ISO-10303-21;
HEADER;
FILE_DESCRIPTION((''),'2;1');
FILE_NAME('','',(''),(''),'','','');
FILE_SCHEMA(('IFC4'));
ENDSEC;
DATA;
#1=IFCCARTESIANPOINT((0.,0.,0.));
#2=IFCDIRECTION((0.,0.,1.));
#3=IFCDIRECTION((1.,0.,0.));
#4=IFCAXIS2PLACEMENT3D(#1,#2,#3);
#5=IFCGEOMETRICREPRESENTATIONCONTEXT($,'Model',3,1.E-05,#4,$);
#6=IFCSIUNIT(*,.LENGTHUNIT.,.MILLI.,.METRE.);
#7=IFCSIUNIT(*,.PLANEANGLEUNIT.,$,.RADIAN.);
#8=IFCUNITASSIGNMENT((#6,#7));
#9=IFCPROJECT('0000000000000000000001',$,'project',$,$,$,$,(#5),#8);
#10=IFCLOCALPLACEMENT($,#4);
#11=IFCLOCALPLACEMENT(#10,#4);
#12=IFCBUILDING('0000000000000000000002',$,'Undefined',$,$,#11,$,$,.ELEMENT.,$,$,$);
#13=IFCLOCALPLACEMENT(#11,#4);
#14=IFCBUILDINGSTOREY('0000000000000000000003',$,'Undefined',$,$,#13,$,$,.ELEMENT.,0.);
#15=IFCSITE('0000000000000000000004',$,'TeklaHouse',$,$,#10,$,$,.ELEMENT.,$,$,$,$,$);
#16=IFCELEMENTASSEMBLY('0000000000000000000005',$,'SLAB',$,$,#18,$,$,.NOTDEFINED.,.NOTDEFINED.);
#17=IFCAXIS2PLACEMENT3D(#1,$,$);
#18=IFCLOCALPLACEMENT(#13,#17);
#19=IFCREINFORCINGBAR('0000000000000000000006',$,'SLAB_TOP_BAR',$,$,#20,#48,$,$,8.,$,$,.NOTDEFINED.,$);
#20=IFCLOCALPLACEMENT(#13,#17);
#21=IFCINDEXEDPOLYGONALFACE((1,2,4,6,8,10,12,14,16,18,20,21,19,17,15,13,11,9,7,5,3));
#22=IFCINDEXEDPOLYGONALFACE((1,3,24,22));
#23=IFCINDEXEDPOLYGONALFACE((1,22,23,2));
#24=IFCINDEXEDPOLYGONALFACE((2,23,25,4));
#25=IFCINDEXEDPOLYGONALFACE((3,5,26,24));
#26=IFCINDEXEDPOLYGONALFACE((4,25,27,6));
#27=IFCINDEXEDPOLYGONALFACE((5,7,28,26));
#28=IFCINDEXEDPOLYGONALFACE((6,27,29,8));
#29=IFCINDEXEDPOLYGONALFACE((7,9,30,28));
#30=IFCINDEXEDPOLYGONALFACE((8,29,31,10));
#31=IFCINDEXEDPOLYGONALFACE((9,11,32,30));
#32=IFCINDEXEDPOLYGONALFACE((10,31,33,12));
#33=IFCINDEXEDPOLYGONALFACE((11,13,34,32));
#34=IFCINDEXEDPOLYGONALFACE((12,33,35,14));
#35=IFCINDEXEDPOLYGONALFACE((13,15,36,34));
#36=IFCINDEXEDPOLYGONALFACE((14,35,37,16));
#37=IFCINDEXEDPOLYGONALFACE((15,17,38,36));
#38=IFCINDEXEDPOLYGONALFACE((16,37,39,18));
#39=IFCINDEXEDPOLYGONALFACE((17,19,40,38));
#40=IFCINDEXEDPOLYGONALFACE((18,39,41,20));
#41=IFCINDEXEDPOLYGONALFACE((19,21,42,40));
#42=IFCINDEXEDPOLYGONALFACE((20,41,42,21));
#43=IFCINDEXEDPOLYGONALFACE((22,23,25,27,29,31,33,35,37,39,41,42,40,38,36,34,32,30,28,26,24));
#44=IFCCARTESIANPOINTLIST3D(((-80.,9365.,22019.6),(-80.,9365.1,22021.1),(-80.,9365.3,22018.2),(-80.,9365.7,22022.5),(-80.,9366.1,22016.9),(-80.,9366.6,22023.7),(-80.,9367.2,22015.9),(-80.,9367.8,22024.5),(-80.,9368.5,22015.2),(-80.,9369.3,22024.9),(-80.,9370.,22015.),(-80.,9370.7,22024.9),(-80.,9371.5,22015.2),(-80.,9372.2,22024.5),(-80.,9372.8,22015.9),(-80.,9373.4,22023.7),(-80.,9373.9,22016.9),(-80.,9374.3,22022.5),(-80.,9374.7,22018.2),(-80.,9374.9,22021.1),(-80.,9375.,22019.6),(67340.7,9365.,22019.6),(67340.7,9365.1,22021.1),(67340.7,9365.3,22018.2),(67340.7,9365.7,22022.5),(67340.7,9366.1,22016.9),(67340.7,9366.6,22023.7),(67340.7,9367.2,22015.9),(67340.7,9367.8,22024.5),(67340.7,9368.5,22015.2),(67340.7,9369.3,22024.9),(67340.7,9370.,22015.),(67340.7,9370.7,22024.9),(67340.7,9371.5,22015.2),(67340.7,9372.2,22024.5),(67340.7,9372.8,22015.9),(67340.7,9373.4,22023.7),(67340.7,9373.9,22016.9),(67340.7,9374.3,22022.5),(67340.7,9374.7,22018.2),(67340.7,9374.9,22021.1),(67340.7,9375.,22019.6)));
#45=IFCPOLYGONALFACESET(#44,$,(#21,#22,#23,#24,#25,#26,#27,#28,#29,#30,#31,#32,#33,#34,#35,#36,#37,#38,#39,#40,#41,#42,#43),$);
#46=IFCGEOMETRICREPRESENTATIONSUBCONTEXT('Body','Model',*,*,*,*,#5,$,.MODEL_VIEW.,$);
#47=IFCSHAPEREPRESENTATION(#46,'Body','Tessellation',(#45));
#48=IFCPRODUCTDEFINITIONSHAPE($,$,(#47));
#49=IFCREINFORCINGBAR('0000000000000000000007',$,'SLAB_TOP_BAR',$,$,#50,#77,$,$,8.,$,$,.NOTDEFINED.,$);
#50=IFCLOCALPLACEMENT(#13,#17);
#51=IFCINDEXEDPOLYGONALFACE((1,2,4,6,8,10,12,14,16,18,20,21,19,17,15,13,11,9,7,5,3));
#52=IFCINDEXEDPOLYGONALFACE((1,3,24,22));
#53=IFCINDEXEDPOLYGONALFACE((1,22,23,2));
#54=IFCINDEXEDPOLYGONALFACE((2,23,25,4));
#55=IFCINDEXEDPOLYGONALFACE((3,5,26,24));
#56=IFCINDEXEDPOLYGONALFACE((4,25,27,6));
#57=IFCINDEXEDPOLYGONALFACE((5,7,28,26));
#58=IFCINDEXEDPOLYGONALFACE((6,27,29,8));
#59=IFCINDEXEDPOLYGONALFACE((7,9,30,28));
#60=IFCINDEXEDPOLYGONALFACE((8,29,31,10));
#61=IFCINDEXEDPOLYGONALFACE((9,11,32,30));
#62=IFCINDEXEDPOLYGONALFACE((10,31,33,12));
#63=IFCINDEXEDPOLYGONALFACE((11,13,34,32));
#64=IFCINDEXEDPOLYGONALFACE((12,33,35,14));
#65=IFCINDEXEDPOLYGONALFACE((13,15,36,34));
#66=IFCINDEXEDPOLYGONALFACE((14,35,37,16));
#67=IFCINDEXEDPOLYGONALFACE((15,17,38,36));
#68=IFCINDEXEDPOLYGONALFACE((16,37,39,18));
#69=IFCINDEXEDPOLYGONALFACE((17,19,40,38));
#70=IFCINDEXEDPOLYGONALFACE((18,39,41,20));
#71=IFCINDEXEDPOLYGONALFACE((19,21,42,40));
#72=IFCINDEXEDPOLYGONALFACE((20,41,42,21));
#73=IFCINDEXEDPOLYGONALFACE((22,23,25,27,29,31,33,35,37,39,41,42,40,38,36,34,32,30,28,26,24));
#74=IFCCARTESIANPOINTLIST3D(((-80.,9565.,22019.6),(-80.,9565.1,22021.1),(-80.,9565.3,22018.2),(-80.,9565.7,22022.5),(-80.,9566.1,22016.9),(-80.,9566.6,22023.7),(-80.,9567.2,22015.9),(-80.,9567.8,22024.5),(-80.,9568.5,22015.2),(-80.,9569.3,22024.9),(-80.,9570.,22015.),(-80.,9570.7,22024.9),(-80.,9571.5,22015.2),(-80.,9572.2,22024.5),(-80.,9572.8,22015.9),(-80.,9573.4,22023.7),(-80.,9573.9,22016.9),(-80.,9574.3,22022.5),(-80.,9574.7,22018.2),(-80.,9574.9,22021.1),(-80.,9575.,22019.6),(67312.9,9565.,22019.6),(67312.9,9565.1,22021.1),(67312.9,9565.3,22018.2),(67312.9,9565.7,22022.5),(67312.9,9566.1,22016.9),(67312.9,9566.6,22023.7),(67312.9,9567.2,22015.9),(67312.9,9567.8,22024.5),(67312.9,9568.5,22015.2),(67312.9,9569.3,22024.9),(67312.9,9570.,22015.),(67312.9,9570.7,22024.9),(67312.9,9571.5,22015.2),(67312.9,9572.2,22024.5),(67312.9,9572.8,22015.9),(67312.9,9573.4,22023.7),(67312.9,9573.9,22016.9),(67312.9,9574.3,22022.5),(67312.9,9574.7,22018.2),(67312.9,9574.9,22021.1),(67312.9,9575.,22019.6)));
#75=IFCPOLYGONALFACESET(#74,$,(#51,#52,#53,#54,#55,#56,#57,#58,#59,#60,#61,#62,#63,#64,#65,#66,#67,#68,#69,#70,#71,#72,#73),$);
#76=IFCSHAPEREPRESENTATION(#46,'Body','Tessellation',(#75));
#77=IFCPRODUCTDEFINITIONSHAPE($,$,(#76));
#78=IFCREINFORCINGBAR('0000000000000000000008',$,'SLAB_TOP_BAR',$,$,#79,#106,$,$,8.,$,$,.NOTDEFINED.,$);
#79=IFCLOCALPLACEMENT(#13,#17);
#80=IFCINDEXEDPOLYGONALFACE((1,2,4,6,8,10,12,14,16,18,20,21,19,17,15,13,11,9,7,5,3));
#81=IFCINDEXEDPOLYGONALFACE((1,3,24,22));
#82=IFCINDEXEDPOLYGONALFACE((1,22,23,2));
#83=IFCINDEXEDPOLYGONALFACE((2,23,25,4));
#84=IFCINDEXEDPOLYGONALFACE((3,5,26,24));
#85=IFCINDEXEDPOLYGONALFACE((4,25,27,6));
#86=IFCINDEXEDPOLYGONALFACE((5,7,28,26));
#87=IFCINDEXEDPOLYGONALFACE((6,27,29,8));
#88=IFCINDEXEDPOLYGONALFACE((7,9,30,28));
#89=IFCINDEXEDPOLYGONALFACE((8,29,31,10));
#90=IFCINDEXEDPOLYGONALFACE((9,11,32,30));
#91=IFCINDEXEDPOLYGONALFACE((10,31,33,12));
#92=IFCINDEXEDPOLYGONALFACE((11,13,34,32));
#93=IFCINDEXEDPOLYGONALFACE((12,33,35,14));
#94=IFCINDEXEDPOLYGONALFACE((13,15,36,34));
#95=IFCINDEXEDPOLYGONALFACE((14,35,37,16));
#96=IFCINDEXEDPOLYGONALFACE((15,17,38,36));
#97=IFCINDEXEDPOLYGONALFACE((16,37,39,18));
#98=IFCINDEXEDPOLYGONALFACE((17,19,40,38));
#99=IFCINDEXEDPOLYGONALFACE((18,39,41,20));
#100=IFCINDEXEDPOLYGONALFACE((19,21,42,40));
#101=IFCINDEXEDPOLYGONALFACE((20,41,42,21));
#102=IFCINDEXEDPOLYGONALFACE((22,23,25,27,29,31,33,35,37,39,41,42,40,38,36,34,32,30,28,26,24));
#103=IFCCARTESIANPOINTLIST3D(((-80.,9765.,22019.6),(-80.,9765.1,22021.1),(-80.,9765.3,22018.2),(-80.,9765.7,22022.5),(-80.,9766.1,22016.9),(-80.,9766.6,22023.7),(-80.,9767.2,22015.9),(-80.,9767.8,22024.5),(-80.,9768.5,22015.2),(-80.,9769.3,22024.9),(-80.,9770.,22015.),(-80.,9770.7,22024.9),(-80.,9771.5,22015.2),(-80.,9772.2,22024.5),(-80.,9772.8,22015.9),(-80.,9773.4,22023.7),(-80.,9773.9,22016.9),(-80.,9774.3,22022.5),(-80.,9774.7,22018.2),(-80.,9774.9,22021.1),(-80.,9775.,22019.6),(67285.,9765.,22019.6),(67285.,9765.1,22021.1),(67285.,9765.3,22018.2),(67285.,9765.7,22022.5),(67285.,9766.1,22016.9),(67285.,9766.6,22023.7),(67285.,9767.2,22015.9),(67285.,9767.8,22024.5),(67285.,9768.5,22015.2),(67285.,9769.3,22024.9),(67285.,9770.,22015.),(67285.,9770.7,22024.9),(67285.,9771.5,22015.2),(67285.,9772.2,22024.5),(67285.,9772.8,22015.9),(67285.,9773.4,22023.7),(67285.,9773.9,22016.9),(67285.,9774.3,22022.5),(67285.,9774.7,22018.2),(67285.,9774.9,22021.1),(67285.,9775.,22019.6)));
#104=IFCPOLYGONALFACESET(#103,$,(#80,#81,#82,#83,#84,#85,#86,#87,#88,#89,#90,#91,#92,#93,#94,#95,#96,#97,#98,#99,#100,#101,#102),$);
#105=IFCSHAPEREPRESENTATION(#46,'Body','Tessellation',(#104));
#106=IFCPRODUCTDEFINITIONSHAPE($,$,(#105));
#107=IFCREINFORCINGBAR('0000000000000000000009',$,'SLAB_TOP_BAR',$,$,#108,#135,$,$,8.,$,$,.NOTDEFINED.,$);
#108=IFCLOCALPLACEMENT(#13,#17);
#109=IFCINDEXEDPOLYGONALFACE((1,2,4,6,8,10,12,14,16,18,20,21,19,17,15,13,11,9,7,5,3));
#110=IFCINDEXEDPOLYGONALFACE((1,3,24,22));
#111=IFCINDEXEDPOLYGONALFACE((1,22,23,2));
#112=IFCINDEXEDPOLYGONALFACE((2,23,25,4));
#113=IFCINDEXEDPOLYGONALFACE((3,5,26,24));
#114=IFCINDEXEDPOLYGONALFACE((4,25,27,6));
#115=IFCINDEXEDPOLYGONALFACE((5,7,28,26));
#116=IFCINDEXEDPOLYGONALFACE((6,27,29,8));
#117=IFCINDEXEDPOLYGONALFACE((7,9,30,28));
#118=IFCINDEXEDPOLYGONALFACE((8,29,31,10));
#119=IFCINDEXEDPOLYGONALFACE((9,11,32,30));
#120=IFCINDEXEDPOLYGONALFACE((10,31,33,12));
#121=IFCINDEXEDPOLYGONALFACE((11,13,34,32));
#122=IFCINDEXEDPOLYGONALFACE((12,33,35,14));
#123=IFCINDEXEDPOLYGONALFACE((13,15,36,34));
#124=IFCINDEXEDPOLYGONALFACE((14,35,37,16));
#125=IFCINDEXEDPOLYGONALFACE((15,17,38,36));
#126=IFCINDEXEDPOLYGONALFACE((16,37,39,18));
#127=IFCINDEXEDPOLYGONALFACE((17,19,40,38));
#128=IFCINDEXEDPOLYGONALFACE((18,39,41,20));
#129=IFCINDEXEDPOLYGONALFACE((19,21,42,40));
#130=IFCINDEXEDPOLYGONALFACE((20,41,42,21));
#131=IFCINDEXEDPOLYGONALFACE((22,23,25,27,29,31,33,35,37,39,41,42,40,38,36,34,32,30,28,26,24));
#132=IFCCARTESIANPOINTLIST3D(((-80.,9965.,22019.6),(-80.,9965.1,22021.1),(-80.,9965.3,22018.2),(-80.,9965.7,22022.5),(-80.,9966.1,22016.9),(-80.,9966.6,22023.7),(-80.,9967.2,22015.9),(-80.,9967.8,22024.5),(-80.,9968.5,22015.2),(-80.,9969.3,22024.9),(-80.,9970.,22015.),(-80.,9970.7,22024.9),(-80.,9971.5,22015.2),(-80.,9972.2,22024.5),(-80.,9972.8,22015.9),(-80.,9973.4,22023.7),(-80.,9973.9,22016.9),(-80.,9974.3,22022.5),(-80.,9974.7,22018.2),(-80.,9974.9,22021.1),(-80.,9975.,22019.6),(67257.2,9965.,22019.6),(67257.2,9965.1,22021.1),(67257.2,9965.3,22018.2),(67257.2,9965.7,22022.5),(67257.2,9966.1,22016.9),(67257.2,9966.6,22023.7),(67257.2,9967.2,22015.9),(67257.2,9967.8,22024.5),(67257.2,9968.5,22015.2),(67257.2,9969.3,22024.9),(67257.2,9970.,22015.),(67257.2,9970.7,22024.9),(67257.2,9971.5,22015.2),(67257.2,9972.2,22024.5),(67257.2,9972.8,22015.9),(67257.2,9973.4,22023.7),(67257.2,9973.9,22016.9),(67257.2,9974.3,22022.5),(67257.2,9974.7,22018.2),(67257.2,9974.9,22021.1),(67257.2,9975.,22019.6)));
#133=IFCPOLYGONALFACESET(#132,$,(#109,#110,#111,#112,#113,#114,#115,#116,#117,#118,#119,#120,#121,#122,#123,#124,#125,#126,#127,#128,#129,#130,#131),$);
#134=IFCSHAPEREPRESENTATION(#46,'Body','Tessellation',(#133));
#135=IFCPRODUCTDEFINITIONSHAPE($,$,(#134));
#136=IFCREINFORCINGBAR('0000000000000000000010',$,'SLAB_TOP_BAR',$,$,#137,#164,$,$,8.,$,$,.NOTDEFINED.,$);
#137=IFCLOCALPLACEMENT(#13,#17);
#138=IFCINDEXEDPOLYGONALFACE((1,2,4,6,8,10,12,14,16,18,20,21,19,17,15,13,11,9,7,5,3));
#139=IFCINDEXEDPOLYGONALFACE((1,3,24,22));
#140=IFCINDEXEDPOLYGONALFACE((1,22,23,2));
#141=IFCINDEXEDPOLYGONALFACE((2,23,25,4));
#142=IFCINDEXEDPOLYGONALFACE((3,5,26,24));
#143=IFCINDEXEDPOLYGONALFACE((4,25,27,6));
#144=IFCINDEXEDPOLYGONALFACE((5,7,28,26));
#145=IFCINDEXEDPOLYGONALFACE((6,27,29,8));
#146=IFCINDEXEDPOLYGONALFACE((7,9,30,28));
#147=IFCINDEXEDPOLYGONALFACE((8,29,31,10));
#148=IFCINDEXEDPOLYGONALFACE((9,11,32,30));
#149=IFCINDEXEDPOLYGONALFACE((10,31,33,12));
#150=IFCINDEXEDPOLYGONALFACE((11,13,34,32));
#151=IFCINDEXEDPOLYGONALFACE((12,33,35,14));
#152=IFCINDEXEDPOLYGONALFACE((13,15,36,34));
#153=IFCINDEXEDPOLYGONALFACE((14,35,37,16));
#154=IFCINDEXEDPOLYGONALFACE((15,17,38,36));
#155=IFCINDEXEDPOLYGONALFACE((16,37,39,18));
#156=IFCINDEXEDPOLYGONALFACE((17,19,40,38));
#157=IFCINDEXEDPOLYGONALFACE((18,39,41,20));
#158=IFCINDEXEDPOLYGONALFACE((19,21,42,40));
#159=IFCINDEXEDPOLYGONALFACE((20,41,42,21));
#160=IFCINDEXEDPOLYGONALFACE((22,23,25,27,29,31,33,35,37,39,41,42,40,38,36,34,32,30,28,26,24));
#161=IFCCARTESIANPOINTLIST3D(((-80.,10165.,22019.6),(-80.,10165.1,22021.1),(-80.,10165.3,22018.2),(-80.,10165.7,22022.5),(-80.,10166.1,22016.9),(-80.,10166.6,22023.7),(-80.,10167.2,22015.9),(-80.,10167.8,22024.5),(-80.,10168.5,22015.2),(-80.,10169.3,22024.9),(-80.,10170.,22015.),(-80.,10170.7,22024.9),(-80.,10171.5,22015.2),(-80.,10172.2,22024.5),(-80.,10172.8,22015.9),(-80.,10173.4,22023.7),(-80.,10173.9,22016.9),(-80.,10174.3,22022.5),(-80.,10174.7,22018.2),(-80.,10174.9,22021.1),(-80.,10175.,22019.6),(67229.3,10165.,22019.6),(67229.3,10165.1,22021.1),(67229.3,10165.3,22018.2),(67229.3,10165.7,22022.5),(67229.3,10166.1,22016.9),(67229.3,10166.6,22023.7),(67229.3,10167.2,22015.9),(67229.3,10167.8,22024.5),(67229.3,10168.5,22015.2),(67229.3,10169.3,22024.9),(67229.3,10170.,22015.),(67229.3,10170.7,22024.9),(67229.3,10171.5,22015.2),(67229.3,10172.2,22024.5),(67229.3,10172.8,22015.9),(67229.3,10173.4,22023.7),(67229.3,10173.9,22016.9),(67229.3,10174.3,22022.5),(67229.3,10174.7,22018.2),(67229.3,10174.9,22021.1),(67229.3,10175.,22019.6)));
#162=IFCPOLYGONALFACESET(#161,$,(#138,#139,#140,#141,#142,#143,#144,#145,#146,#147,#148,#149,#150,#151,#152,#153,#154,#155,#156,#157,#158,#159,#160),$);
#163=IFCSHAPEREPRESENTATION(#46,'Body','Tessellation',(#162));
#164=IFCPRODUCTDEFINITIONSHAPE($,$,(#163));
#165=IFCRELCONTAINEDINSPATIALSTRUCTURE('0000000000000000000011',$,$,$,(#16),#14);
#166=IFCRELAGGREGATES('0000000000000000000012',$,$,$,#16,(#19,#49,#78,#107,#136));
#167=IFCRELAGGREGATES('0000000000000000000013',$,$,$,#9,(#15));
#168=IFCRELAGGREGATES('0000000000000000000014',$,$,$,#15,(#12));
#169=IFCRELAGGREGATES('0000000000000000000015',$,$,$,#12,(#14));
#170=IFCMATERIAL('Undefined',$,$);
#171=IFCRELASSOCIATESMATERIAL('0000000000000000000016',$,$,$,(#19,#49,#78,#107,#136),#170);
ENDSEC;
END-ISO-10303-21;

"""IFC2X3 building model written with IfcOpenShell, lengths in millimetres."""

from ifc_helpers import new_model, entity, si_unit, frame, origin_with_axes, place, context, subcontext, project, spatial, source, transform, mapped, material, element, aggregate, save


model = new_model("IFC2X3")

# Units and contexts
model_context = context("Model", 3, precision=1e-05, world=origin_with_axes())
body_context = subcontext(model_context, "Body", "Model", "MODEL_VIEW")
ifc_project = project(units=[si_unit("LENGTHUNIT", "METRE", prefix="MILLI"), si_unit("PLANEANGLEUNIT", "RADIAN")], contexts=[model_context])

# Site, building, storey
site_placement = place(None, origin_with_axes())
site = spatial("IfcSite", under=ifc_project, at=site_placement, Name="TeklaHouse", CompositionType="ELEMENT")
building_placement = place(site_placement, origin_with_axes())
building = spatial("IfcBuilding", under=site, at=building_placement, Name="Undefined", CompositionType="ELEMENT")
storey_placement = place(building_placement, origin_with_axes())
storey = spatial("IfcBuildingStorey", under=building, at=storey_placement, Name="Undefined", CompositionType="ELEMENT", Elevation=0.0)

# Shared definitions
ifc_material_1 = material(Name="Undefined")

# Element assembly, reinforcing bars
assembly_1_placement = place(storey_placement, origin_with_axes())
assembly_1 = element("IfcElementAssembly", 1, at=assembly_1_placement, inside=storey, Name="SLAB", AssemblyPlace="NOTDEFINED", PredefinedType="NOTDEFINED")
shared_shape_1 = source(origin_with_axes(), body_context, "Body", "AdvancedSweptSolid", [
    entity("IfcSweptDiskSolid", entity("IfcTrimmedCurve", entity("IfcLine", entity("IfcCartesianPoint", [0.0, 0.0, 0.0]), entity("IfcVector", entity("IfcDirection", [1.0, 0.0, 0.0]), 1.0)), [entity("IfcParameterValue", 0.0)], [entity("IfcParameterValue", 67420.729227)], True, "PARAMETER"), 5.0, None, 0.0, 67420.7),
])
reinforcing_bar_1_placement = place(assembly_1_placement, frame((67340.7, 9370.0, 22020.0), z_axis=(0.0, 0.0, -1.0), x_axis=(-1.0, 0.0, 0.0)))
reinforcing_bar_1 = element("IfcReinforcingBar", 2, at=reinforcing_bar_1_placement, material=ifc_material_1, Name="SLAB_TOP_BAR", BarRole="NOTDEFINED", NominalDiameter=8.0, context=body_context, shape_type="MappedRepresentation", body=[
    mapped(shared_shape_1, transform((0.0, 0.0, 0.0))),
])
shared_shape_2 = source(origin_with_axes(), body_context, "Body", "AdvancedSweptSolid", [
    entity("IfcSweptDiskSolid", entity("IfcTrimmedCurve", entity("IfcLine", entity("IfcCartesianPoint", [0.0, 0.0, 0.0]), entity("IfcVector", entity("IfcDirection", [1.0, 0.0, 0.0]), 1.0)), [entity("IfcParameterValue", 0.0)], [entity("IfcParameterValue", 67392.88277)], True, "PARAMETER"), 5.0, None, 0.0, 67392.9),
])
reinforcing_bar_2_placement = place(assembly_1_placement, frame((67312.9, 9570.0, 22020.0), z_axis=(0.0, 0.0, -1.0), x_axis=(-1.0, 0.0, 0.0)))
reinforcing_bar_2 = element("IfcReinforcingBar", 3, at=reinforcing_bar_2_placement, material=ifc_material_1, Name="SLAB_TOP_BAR", BarRole="NOTDEFINED", NominalDiameter=8.0, context=body_context, shape_type="MappedRepresentation", body=[
    mapped(shared_shape_2, transform((0.0, 0.0, 0.0))),
])
shared_shape_3 = source(origin_with_axes(), body_context, "Body", "AdvancedSweptSolid", [
    entity("IfcSweptDiskSolid", entity("IfcTrimmedCurve", entity("IfcLine", entity("IfcCartesianPoint", [0.0, 0.0, 0.0]), entity("IfcVector", entity("IfcDirection", [1.0, 0.0, 0.0]), 1.0)), [entity("IfcParameterValue", 0.0)], [entity("IfcParameterValue", 67365.036313)], True, "PARAMETER"), 5.0, None, 0.0, 67365.0),
])
reinforcing_bar_3_placement = place(assembly_1_placement, frame((67285.0, 9770.0, 22020.0), z_axis=(0.0, 0.0, -1.0), x_axis=(-1.0, 0.0, 0.0)))
reinforcing_bar_3 = element("IfcReinforcingBar", 4, at=reinforcing_bar_3_placement, material=ifc_material_1, Name="SLAB_TOP_BAR", BarRole="NOTDEFINED", NominalDiameter=8.0, context=body_context, shape_type="MappedRepresentation", body=[
    mapped(shared_shape_3, transform((0.0, 0.0, 0.0))),
])
shared_shape_4 = source(origin_with_axes(), body_context, "Body", "AdvancedSweptSolid", [
    entity("IfcSweptDiskSolid", entity("IfcTrimmedCurve", entity("IfcLine", entity("IfcCartesianPoint", [0.0, 0.0, 0.0]), entity("IfcVector", entity("IfcDirection", [1.0, 0.0, 0.0]), 1.0)), [entity("IfcParameterValue", 0.0)], [entity("IfcParameterValue", 67337.189856)], True, "PARAMETER"), 5.0, None, 0.0, 67337.2),
])
reinforcing_bar_4_placement = place(assembly_1_placement, frame((67257.2, 9970.0, 22020.0), z_axis=(0.0, 0.0, -1.0), x_axis=(-1.0, 0.0, 0.0)))
reinforcing_bar_4 = element("IfcReinforcingBar", 5, at=reinforcing_bar_4_placement, material=ifc_material_1, Name="SLAB_TOP_BAR", BarRole="NOTDEFINED", NominalDiameter=8.0, context=body_context, shape_type="MappedRepresentation", body=[
    mapped(shared_shape_4, transform((0.0, 0.0, 0.0))),
])
shared_shape_5 = source(origin_with_axes(), body_context, "Body", "AdvancedSweptSolid", [
    entity("IfcSweptDiskSolid", entity("IfcTrimmedCurve", entity("IfcLine", entity("IfcCartesianPoint", [0.0, 0.0, 0.0]), entity("IfcVector", entity("IfcDirection", [1.0, 0.0, 0.0]), 1.0)), [entity("IfcParameterValue", 0.0)], [entity("IfcParameterValue", 67309.343399)], True, "PARAMETER"), 5.0, None, 0.0, 67309.3),
])
reinforcing_bar_5_placement = place(assembly_1_placement, frame((67229.3, 10170.0, 22020.0), z_axis=(0.0, 0.0, -1.0), x_axis=(-1.0, 0.0, 0.0)))
reinforcing_bar_5 = element("IfcReinforcingBar", 6, at=reinforcing_bar_5_placement, material=ifc_material_1, Name="SLAB_TOP_BAR", BarRole="NOTDEFINED", NominalDiameter=8.0, context=body_context, shape_type="MappedRepresentation", body=[
    mapped(shared_shape_5, transform((0.0, 0.0, 0.0))),
])
aggregate(assembly_1, [reinforcing_bar_1, reinforcing_bar_2, reinforcing_bar_3, reinforcing_bar_4, reinforcing_bar_5])

save(model, "model.ifc")
